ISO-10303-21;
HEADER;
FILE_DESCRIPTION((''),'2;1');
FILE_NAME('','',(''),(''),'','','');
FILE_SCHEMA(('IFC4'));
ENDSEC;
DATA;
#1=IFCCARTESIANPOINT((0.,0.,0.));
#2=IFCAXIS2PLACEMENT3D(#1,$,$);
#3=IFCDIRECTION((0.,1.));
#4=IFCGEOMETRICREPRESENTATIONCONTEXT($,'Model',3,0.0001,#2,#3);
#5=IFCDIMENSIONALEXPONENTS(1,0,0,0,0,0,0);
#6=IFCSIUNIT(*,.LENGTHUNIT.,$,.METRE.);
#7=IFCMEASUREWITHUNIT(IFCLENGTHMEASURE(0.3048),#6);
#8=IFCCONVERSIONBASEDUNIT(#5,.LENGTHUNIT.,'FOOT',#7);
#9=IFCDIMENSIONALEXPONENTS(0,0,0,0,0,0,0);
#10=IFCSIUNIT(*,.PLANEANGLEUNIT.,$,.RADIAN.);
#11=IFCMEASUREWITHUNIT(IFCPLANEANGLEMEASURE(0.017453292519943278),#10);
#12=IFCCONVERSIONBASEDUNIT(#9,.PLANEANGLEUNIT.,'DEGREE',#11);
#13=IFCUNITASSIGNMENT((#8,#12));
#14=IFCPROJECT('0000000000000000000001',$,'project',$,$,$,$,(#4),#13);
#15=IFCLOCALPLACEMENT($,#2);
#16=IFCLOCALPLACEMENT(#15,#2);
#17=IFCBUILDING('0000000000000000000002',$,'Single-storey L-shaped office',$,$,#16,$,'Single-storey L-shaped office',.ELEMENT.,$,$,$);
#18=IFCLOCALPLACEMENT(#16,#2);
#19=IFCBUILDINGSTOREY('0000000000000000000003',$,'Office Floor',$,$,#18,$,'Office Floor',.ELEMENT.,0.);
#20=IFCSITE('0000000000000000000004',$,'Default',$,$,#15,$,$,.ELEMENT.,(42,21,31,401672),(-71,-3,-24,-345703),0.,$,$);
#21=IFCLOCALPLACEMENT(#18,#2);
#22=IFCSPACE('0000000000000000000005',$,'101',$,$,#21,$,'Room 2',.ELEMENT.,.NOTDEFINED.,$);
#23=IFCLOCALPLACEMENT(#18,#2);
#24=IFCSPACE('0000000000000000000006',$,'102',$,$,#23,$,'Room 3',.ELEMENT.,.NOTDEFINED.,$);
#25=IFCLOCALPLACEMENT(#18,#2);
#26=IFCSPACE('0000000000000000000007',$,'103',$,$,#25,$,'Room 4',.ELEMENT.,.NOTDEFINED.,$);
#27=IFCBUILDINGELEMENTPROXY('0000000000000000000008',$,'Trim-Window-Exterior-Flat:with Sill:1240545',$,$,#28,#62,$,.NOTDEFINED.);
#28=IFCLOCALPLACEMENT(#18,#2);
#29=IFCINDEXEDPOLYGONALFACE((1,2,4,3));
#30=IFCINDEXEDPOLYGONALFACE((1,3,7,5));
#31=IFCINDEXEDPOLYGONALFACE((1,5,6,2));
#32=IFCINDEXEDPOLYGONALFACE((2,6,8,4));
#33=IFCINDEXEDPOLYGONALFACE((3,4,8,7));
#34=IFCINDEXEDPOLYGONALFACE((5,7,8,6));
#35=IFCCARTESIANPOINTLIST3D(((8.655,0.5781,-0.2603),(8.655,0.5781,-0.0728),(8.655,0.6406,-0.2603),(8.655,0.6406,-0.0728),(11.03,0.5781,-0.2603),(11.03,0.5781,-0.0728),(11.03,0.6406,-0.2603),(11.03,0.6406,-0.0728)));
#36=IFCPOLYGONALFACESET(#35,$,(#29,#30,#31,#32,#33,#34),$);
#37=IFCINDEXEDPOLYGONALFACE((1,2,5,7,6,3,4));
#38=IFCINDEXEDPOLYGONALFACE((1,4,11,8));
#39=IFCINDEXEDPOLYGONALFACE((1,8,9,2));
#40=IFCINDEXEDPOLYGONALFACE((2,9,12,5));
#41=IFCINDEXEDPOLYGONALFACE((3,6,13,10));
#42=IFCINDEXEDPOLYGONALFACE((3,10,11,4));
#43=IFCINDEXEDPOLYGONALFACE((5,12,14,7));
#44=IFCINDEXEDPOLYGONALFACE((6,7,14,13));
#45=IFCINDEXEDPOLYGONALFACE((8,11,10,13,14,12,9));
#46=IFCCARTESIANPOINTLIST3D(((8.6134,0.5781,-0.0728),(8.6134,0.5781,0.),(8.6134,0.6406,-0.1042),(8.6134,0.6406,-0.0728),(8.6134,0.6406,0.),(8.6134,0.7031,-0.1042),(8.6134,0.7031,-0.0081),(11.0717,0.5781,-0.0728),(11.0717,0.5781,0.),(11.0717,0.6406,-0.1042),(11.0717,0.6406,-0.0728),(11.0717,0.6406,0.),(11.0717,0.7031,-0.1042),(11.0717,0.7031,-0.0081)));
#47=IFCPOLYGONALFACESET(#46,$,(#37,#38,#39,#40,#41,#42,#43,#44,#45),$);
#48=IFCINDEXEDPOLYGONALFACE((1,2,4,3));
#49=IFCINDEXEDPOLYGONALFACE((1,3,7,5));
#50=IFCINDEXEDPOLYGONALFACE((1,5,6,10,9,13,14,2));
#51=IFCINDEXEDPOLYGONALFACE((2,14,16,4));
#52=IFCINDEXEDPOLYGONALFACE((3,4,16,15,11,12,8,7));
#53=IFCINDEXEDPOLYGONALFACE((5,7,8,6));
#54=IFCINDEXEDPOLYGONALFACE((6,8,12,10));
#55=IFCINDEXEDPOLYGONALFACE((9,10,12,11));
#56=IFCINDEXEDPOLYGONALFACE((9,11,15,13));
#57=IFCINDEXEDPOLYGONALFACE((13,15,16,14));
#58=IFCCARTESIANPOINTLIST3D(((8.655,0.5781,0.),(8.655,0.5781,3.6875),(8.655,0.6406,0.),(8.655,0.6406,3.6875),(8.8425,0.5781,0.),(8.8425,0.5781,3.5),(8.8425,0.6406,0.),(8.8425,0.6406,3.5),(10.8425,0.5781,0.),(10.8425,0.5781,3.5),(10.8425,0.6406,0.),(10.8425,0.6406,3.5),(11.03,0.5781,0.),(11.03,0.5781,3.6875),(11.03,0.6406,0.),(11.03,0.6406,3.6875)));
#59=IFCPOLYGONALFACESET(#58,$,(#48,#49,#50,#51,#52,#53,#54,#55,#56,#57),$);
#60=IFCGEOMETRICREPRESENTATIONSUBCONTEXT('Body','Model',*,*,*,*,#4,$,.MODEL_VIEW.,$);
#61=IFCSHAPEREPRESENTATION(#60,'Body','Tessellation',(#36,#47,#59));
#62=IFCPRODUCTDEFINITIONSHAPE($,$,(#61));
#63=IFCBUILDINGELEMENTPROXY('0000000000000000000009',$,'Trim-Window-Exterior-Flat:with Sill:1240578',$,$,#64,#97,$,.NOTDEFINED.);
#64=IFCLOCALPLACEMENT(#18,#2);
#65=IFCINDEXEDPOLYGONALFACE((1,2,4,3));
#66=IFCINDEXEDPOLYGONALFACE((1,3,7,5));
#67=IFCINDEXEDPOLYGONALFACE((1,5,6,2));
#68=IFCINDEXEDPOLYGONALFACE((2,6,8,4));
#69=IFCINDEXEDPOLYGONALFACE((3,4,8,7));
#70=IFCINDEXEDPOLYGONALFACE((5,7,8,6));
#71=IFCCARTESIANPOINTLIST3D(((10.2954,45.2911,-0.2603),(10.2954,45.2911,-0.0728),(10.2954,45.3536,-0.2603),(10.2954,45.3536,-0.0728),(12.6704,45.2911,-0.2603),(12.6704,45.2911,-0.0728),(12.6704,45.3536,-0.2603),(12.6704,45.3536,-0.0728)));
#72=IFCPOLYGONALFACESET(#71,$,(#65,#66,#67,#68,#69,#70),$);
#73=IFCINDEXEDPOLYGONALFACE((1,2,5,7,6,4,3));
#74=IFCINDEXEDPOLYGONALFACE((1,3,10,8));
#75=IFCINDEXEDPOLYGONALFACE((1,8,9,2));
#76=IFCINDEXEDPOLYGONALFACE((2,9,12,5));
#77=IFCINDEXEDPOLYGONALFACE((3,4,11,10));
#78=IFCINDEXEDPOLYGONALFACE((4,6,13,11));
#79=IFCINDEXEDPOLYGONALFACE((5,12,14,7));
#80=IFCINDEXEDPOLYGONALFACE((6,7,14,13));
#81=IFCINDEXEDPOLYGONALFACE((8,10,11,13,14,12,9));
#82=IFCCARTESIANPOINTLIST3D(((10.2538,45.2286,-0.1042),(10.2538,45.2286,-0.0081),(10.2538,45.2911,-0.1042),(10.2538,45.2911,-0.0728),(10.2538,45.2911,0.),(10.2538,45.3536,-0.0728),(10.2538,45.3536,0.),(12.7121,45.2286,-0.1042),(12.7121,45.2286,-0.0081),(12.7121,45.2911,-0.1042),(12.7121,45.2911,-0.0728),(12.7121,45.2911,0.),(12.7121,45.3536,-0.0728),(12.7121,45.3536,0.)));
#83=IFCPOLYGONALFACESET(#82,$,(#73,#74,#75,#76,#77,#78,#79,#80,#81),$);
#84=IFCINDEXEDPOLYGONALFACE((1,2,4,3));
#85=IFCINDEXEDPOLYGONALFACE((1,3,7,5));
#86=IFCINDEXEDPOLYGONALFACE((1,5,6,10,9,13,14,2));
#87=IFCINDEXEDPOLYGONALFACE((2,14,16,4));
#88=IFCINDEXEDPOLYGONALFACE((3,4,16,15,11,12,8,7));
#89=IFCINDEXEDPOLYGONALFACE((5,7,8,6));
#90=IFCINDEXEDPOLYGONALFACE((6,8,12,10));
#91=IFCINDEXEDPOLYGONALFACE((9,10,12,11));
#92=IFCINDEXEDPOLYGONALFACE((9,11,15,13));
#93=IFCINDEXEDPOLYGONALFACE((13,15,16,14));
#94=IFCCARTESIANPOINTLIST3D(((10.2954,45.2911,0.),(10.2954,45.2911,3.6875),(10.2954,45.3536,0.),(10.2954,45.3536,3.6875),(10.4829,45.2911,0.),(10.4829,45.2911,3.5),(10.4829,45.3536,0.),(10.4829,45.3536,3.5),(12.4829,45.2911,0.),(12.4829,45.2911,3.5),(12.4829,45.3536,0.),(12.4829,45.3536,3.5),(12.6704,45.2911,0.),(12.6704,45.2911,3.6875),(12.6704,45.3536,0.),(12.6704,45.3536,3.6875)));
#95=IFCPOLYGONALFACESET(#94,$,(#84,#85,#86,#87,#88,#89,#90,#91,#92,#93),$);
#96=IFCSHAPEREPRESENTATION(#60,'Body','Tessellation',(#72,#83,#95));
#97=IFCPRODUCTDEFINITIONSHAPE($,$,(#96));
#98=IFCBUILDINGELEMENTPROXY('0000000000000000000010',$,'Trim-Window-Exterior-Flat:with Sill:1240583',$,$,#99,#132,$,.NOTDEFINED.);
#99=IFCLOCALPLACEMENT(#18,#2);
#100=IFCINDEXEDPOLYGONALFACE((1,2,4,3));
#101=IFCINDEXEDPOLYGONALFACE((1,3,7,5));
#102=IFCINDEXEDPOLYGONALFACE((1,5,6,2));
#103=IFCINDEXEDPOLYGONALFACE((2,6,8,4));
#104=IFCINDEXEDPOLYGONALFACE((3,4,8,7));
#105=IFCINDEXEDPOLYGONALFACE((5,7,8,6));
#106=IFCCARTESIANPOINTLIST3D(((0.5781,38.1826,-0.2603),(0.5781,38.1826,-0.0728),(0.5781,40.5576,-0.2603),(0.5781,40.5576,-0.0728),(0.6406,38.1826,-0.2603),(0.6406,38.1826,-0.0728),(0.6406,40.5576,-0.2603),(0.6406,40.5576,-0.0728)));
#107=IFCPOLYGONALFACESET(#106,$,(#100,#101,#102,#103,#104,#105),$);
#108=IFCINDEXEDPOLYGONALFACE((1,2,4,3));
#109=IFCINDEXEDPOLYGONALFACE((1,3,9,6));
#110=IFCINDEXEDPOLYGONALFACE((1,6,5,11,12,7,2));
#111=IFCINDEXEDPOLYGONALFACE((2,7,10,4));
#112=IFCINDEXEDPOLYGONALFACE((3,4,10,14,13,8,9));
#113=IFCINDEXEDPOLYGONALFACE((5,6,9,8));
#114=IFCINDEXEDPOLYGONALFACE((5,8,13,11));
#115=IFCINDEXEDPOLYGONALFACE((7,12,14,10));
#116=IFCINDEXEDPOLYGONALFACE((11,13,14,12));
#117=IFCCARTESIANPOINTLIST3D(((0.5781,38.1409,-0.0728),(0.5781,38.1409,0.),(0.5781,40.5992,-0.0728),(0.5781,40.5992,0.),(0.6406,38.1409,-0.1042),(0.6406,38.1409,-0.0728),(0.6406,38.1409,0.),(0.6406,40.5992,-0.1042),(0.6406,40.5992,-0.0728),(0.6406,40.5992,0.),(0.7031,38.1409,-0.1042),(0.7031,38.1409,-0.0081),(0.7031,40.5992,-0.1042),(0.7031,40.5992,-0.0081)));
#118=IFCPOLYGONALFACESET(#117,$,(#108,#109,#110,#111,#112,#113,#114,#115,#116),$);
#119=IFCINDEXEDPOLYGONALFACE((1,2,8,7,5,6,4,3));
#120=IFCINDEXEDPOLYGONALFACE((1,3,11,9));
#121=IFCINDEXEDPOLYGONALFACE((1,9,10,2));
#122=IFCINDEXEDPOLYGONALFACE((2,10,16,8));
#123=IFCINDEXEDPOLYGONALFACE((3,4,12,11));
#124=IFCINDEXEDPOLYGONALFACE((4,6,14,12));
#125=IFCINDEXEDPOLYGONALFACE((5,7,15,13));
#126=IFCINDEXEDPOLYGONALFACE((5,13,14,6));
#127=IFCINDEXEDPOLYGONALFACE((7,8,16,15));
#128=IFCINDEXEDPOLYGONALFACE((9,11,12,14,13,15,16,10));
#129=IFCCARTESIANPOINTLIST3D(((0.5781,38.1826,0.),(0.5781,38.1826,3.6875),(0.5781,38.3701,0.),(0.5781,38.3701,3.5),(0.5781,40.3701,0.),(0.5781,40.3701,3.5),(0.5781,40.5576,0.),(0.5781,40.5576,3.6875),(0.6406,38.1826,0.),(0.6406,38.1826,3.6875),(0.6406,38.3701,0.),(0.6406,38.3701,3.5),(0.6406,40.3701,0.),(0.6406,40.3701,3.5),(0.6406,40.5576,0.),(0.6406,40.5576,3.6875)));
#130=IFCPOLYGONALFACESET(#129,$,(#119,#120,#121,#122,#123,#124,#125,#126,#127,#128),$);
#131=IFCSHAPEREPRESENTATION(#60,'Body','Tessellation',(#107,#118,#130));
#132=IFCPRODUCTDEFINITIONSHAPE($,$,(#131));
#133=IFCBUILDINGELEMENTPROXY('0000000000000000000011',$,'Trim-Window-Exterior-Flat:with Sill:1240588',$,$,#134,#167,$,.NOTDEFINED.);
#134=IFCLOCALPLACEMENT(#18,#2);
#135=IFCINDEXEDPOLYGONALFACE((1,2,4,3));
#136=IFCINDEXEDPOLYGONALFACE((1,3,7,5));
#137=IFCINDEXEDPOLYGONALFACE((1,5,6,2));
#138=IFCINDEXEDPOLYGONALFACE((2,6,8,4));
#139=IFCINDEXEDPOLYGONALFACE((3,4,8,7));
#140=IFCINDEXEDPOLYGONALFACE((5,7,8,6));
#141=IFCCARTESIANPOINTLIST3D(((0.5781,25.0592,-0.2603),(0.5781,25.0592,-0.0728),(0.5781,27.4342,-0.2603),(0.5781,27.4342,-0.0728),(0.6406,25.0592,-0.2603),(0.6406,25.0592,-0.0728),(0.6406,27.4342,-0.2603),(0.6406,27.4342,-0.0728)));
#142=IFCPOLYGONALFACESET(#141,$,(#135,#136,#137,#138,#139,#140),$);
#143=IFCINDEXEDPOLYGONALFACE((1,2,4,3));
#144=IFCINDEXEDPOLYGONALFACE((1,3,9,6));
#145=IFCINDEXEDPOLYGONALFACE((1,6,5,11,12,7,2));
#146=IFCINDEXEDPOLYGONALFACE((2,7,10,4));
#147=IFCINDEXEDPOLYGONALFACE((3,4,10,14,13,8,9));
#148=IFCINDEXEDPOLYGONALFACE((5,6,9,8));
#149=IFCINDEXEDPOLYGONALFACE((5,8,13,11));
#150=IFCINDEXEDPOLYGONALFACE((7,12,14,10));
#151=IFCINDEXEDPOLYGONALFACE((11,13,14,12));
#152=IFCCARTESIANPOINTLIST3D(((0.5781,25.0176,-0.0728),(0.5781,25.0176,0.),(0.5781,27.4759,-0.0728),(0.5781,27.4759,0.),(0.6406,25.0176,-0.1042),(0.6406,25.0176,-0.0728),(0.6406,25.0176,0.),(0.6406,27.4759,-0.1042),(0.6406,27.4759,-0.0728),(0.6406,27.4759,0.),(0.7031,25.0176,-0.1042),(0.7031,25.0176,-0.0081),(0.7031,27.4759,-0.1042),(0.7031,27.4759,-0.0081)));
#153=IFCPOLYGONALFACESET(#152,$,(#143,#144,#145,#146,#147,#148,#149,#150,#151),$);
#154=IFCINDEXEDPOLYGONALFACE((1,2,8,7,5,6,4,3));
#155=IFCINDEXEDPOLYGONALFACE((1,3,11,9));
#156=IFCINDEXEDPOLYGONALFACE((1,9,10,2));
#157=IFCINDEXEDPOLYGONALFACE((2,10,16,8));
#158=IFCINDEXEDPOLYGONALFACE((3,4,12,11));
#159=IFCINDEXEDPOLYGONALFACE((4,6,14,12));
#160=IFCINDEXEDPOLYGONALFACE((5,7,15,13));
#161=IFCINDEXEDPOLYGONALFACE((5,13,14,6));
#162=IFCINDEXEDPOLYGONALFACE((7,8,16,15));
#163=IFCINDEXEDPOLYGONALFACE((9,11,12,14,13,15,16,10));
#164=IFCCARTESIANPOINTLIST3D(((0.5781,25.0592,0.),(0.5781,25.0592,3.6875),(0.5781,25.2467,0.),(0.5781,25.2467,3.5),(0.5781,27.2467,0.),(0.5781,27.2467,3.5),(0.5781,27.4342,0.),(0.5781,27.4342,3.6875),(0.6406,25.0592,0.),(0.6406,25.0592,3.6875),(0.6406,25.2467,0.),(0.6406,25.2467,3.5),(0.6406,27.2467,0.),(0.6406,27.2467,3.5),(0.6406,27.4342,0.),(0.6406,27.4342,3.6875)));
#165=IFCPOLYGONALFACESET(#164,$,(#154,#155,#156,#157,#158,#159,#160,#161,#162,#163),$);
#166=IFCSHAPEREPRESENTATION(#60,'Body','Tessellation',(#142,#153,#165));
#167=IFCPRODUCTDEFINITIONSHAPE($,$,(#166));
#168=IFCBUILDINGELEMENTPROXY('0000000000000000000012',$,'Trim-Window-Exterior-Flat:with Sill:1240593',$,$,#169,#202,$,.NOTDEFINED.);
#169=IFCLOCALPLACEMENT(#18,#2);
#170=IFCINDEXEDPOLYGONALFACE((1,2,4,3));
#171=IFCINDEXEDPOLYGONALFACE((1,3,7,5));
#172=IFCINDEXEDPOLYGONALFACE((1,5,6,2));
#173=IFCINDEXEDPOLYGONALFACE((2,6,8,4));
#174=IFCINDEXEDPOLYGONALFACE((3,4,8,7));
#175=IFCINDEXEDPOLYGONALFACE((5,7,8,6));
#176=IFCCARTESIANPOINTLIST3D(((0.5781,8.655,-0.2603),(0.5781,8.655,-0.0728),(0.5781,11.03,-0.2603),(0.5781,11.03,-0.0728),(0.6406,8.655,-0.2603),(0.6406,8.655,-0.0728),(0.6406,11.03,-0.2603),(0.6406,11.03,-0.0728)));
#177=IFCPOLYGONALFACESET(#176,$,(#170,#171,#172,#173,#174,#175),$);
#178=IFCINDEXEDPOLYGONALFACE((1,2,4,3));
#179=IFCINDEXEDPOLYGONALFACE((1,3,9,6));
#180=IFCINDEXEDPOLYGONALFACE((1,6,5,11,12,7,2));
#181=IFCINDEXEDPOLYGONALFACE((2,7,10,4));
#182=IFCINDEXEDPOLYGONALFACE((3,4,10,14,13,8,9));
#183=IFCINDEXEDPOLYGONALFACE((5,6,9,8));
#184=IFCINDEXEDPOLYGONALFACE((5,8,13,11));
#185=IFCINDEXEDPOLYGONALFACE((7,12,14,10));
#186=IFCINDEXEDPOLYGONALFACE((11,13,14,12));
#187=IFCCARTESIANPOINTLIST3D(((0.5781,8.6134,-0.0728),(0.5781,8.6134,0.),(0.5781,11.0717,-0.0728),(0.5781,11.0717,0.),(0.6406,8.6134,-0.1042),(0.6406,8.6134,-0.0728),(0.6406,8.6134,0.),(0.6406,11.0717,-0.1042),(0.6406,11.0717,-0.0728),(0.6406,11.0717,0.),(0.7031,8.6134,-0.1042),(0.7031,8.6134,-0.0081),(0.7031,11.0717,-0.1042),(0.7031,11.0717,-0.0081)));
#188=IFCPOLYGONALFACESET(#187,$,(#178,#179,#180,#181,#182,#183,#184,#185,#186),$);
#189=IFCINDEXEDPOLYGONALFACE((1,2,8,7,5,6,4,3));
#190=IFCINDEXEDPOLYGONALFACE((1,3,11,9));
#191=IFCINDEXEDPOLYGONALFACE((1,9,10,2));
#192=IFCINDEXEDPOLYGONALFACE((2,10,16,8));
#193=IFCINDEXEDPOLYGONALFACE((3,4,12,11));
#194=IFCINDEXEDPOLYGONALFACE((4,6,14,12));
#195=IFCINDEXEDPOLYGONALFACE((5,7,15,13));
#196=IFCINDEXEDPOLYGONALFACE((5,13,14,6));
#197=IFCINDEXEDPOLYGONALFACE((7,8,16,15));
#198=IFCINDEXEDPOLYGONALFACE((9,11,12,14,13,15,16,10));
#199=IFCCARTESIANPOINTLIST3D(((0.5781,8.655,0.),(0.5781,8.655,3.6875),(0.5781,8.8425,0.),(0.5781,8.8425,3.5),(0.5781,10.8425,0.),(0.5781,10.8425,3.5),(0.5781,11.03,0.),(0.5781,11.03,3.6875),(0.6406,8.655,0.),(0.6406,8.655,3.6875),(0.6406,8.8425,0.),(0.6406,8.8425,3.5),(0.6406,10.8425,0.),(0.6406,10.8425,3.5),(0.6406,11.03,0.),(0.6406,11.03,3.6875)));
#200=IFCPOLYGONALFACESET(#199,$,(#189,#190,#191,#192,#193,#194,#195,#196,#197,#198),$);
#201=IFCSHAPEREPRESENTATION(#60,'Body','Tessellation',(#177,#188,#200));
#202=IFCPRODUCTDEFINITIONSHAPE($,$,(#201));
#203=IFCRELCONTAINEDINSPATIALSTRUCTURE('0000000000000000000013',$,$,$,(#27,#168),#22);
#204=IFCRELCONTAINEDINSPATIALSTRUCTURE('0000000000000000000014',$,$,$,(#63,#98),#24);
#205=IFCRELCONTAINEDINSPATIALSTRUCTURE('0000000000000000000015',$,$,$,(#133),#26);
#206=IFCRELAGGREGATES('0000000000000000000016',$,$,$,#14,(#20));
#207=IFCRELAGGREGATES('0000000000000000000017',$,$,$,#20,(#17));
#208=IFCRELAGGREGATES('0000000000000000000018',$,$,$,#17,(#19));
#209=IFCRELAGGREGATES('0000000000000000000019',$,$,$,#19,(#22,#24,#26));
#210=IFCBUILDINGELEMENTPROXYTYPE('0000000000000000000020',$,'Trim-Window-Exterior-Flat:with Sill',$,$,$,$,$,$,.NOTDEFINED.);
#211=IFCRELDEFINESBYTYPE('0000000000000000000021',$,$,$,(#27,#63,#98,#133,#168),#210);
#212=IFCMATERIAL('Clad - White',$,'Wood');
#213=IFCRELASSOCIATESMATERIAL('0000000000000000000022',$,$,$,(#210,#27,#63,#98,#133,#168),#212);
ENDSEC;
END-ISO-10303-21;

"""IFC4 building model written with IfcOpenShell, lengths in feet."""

from ifc_helpers import new_model, entity, si_unit, converted_unit, direction, frame, origin, place, context, subcontext, project, spatial, indexed_curve, outline, extrude, source, transform, mapped, material, type_object, type_shapes, element, save


model = new_model("IFC4")

# Units and contexts
model_context = context("Model", 3, precision=0.0001, world=origin(), true_north=direction((0.0, 1.0)))
body_context = subcontext(model_context, "Body", "Model", "MODEL_VIEW")
ifc_project = project(units=[converted_unit("LENGTHUNIT", "FOOT", entity("IfcLengthMeasure", 0.3048), si_unit("LENGTHUNIT", "METRE"), dimensions=[1, 0, 0, 0, 0, 0, 0]), converted_unit("PLANEANGLEUNIT", "DEGREE", entity("IfcPlaneAngleMeasure", 0.017453292519943278), si_unit("PLANEANGLEUNIT", "RADIAN"), dimensions=[0, 0, 0, 0, 0, 0, 0])], contexts=[model_context])

# Site, building, storey
site_placement = place(None, origin())
site = spatial("IfcSite", under=ifc_project, at=site_placement, Name="Default", CompositionType="ELEMENT", RefLatitude=(42, 21, 31, 401672), RefLongitude=(-71, -3, -24, -345703), RefElevation=0.0)
building_placement = place(site_placement, origin())
building = spatial("IfcBuilding", under=site, at=building_placement, Name="Single-storey L-shaped office", LongName="Single-storey L-shaped office", CompositionType="ELEMENT")
storey_placement = place(building_placement, origin())
storey = spatial("IfcBuildingStorey", under=building, at=storey_placement, Name="Office Floor", LongName="Office Floor", CompositionType="ELEMENT", Elevation=0.0)

# Shared definitions
ifc_material_1 = material(Name="Clad - White", Category="Wood")

# Shared definitions
space_1_placement = place(storey_placement, origin())
space_1 = spatial("IfcSpace", under=storey, at=space_1_placement, Name="101", LongName="Room 2", CompositionType="ELEMENT", PredefinedType="NOTDEFINED")

# Building element proxy
building_element_proxy_type_1 = type_object("IfcBuildingElementProxyType", Name="Trim-Window-Exterior-Flat:with Sill", PredefinedType="NOTDEFINED", material=ifc_material_1)
shared_shape_1 = source(origin(), body_context, "Body", "SweptSolid", [
    extrude(outline(indexed_curve([(-1.1875, -0.0938), (1.1875, -0.0938), (1.1875, 0.0938), (-1.1875, 0.0938), (-1.1875, -0.0938)], self_intersect=False)), frame((0.0, -3.6665, 0.0), z_axis=(0.0, 0.0, 1.0), x_axis=(-1.0, 0.0, 0.0)), (0.0, 0.0, 1.0), 0.0625),
    extrude(outline(indexed_curve([(-0.0625, -0.0525), (0.0, -0.0525), (0.0, -0.0211), (0.0625, -0.0211), (0.0625, 0.0517), (0.0, 0.0517), (-0.0625, 0.0436), (-0.0625, -0.0525)], self_intersect=False)), frame((-1.2292, -3.5517, 0.0625), z_axis=(1.0, 0.0, 0.0), x_axis=(0.0, 0.0, -1.0)), (0.0, 0.0, 1.0), 2.4583),
    extrude(outline(indexed_curve([(-1.8906, -1.1875), (1.7969, -1.1875), (1.7969, -1.0), (-1.7031, -1.0), (-1.7031, 1.0), (1.7969, 1.0), (1.7969, 1.1875), (-1.8906, 1.1875), (-1.8906, -1.1875)], self_intersect=False)), frame((0.0, -1.7031, 0.0), z_axis=(0.0, 0.0, 1.0), x_axis=(0.0, -1.0, 0.0)), (0.0, 0.0, 1.0), 0.0625),
])
type_shapes(building_element_proxy_type_1, [shared_shape_1])
proxy_1_placement = place(space_1_placement, frame((9.8425, 0.5781, 3.5), z_axis=(0.0, 1.0, 0.0), x_axis=(-1.0, 0.0, 0.0)))
element("IfcBuildingElementProxy", 1, at=proxy_1_placement, inside=space_1, type_object=building_element_proxy_type_1, material=ifc_material_1, Name="Trim-Window-Exterior-Flat:with Sill:1240545", PredefinedType="NOTDEFINED", context=body_context, shape_type="MappedRepresentation", body=[
    mapped(shared_shape_1, transform((0.0, 0.0, 0.0), scale=1.0)),
])

# Shared definitions
space_2_placement = place(storey_placement, origin())
space_2 = spatial("IfcSpace", under=storey, at=space_2_placement, Name="102", LongName="Room 3", CompositionType="ELEMENT", PredefinedType="NOTDEFINED")

# Building element proxies
for number, where, z_axis, x_axis, name in (
    (2, (11.4829, 45.3536, 3.5), (0.0, -1.0, 0.0), (1.0, 0.0, 0.0), "Trim-Window-Exterior-Flat:with Sill:1240578"),
    (3, (0.5781, 39.3701, 3.5), (1.0, 0.0, 0.0), (0.0, 1.0, 0.0), "Trim-Window-Exterior-Flat:with Sill:1240583"),
):
    element("IfcBuildingElementProxy", number, at=place(space_2_placement, frame(where, z_axis=z_axis, x_axis=x_axis)), inside=space_2, type_object=building_element_proxy_type_1, material=ifc_material_1, Name=name, PredefinedType="NOTDEFINED", context=body_context, shape_type="MappedRepresentation", body=[
        mapped(shared_shape_1, transform((0.0, 0.0, 0.0), scale=1.0)),
    ])

# Shared definitions
space_3_placement = place(storey_placement, origin())
space_3 = spatial("IfcSpace", under=storey, at=space_3_placement, Name="103", LongName="Room 4", CompositionType="ELEMENT", PredefinedType="NOTDEFINED")

# Building element proxies
proxy_2_placement = place(space_3_placement, frame((0.5781, 26.2467, 3.5), z_axis=(1.0, 0.0, 0.0), x_axis=(0.0, 1.0, 0.0)))
element("IfcBuildingElementProxy", 4, at=proxy_2_placement, inside=space_3, type_object=building_element_proxy_type_1, material=ifc_material_1, Name="Trim-Window-Exterior-Flat:with Sill:1240588", PredefinedType="NOTDEFINED", context=body_context, shape_type="MappedRepresentation", body=[
    mapped(shared_shape_1, transform((0.0, 0.0, 0.0), scale=1.0)),
])
proxy_3_placement = place(space_1_placement, frame((0.5781, 9.8425, 3.5), z_axis=(1.0, 0.0, 0.0), x_axis=(0.0, 1.0, 0.0)))
element("IfcBuildingElementProxy", 5, at=proxy_3_placement, inside=space_1, type_object=building_element_proxy_type_1, material=ifc_material_1, Name="Trim-Window-Exterior-Flat:with Sill:1240593", PredefinedType="NOTDEFINED", context=body_context, shape_type="MappedRepresentation", body=[
    mapped(shared_shape_1, transform((0.0, 0.0, 0.0), scale=1.0)),
])

save(model, "model.ifc")
